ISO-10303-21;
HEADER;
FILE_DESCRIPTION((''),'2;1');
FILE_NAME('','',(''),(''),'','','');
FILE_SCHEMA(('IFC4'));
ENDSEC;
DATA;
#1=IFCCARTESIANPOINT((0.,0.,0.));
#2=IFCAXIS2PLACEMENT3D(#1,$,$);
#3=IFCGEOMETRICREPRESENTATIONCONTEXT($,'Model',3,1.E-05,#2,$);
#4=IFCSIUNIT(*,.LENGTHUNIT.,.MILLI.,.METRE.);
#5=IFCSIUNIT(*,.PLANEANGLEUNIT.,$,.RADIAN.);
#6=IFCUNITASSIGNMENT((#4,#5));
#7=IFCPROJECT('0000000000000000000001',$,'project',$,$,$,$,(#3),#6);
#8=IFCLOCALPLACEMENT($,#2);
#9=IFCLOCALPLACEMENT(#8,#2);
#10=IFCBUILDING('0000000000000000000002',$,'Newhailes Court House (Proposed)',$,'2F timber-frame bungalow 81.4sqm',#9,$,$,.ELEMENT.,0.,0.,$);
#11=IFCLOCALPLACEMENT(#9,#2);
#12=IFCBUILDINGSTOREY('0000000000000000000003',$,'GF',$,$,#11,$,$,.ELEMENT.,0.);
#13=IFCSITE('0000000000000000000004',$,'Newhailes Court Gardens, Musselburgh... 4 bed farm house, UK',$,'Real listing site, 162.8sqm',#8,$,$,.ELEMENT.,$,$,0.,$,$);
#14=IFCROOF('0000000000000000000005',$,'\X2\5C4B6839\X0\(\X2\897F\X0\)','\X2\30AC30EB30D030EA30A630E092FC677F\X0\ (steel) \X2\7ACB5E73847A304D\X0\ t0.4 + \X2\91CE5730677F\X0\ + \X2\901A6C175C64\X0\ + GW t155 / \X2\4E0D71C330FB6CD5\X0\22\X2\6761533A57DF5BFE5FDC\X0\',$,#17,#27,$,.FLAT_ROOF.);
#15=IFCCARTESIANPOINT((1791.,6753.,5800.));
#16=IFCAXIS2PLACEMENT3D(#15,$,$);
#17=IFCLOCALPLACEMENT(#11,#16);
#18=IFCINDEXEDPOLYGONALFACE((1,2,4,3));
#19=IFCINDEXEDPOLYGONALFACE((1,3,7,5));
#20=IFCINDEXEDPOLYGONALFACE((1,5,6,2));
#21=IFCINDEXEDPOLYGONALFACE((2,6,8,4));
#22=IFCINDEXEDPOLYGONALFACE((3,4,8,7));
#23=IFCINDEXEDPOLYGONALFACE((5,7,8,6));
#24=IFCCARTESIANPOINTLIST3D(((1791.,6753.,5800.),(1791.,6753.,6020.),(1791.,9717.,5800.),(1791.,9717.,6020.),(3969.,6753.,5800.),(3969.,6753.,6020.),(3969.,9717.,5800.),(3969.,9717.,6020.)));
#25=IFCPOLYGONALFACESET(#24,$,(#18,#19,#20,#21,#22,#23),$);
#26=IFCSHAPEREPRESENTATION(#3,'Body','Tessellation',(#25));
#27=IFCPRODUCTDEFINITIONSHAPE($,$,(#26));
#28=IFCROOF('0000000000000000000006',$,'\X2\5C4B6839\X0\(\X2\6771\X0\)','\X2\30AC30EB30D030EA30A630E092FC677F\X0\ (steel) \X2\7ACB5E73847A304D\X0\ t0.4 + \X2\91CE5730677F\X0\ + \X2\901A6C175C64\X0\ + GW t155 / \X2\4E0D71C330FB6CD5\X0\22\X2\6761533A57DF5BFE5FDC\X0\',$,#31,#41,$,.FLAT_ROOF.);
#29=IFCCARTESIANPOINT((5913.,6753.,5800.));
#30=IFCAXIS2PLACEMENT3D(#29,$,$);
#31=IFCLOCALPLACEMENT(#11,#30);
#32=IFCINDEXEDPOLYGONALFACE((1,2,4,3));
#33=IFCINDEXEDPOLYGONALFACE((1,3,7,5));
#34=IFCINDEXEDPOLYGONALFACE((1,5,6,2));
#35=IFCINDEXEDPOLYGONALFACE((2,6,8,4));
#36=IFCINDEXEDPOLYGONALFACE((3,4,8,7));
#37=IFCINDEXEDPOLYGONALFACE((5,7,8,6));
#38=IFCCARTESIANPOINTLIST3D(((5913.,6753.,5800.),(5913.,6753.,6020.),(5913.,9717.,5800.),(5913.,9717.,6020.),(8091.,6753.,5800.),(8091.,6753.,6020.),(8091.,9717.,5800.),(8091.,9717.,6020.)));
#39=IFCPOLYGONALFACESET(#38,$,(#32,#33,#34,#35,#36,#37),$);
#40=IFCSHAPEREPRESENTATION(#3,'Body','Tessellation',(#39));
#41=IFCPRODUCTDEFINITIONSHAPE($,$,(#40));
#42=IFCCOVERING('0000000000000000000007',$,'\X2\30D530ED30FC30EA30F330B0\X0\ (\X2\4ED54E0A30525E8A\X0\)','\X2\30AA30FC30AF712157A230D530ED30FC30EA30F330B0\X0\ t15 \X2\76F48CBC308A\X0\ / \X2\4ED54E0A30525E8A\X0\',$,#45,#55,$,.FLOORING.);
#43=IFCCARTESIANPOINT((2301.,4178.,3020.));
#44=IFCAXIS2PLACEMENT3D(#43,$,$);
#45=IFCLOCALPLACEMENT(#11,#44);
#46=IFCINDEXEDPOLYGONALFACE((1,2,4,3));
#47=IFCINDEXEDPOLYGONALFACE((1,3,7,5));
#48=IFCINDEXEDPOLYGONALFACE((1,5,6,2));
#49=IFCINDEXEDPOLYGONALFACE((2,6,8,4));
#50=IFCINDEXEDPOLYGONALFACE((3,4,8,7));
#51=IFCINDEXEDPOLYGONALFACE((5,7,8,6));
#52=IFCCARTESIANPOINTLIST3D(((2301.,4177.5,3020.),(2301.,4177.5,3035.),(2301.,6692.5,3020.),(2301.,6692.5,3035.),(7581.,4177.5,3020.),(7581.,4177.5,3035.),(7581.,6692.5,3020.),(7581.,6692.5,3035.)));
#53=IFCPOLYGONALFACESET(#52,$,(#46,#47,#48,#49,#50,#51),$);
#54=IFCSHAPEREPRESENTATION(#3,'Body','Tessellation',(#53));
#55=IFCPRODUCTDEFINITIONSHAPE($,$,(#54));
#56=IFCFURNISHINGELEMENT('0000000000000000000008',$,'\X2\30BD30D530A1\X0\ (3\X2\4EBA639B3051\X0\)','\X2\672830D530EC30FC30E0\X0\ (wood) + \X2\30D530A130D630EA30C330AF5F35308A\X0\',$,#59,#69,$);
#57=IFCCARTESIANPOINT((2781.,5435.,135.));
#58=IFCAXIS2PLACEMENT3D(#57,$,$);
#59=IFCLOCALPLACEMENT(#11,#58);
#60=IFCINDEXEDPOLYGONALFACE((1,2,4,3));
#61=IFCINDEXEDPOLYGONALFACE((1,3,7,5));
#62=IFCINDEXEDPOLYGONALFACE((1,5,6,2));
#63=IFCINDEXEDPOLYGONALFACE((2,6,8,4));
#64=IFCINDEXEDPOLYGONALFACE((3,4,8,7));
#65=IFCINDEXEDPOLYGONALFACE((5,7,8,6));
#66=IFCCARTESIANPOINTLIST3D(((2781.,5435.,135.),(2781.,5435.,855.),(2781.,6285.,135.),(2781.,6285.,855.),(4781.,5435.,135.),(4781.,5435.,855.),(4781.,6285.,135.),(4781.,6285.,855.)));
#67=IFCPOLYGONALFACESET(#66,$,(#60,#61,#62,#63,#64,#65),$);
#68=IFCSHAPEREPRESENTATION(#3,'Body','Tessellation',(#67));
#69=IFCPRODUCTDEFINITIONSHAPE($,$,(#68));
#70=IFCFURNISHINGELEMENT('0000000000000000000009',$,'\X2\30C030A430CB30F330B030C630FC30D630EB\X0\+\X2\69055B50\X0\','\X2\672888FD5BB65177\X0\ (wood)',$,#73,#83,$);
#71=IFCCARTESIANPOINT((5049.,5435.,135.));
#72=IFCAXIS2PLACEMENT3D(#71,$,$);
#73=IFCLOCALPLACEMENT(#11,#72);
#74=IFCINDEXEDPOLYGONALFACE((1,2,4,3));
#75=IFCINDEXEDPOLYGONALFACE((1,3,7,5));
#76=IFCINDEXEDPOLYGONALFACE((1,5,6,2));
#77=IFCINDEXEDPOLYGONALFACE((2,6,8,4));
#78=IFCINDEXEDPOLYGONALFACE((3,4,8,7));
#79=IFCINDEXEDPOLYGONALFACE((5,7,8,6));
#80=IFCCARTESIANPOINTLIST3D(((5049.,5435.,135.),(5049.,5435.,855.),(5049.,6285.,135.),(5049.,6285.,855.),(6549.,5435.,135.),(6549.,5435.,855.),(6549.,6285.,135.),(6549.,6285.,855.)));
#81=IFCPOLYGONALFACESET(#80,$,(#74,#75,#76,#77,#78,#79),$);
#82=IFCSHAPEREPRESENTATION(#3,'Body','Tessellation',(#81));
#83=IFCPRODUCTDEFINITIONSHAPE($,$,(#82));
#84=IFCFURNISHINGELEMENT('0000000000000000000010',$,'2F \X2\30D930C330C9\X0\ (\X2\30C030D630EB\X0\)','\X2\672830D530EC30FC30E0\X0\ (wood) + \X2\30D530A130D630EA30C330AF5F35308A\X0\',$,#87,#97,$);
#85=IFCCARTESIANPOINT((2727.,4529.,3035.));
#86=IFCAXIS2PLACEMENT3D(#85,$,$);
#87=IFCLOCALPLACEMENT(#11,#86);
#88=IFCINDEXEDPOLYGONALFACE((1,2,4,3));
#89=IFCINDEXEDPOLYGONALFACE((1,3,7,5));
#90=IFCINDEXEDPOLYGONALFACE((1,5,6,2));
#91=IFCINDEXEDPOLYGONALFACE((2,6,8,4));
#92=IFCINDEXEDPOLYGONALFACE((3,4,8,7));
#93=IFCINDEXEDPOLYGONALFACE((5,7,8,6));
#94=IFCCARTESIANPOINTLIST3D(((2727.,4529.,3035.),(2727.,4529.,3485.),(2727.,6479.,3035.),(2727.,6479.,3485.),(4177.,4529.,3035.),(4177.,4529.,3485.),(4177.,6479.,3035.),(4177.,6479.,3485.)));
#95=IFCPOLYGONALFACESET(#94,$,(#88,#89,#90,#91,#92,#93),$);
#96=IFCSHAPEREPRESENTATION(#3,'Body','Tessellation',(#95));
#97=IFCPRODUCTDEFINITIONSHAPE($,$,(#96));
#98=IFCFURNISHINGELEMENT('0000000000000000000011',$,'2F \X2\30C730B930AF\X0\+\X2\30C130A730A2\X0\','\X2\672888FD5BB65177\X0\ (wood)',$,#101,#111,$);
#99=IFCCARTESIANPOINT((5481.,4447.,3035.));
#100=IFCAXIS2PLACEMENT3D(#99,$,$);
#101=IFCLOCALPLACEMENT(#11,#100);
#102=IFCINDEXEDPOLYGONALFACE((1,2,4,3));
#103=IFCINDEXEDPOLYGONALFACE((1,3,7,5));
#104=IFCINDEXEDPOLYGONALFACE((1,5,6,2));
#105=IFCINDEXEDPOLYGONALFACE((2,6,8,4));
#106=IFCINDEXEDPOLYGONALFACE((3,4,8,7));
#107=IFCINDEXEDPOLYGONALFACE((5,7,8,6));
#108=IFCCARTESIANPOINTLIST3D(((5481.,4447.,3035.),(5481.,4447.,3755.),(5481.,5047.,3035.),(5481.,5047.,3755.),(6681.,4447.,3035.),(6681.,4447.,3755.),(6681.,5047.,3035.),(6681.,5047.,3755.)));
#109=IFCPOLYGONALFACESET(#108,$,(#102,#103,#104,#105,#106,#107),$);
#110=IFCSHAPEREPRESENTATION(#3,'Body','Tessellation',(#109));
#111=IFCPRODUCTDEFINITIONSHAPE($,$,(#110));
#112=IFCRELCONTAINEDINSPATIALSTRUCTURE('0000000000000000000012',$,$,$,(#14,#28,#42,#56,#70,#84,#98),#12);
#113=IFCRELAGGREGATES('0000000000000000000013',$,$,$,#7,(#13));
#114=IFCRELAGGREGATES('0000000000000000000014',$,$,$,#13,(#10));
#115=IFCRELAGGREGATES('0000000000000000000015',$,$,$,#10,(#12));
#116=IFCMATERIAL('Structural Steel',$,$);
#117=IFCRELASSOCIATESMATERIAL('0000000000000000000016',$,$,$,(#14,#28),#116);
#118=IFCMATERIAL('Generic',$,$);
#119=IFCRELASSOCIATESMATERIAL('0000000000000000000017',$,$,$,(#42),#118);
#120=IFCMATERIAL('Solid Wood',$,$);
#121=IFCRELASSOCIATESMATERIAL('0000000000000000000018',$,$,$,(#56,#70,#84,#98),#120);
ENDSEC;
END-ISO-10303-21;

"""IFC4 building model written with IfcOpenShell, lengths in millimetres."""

from ifc_helpers import new_model, si_unit, frame, frame_2d, origin, place, context, project, spatial, rectangle, extrude, material, element, save


model = new_model("IFC4")

# Units and contexts
model_context = context("Model", 3, precision=1e-05, world=origin())
ifc_project = project(units=[si_unit("LENGTHUNIT", "METRE", prefix="MILLI"), si_unit("PLANEANGLEUNIT", "RADIAN")], contexts=[model_context])

# Site, building, storey
site_placement = place(None, origin())
site = spatial("IfcSite", under=ifc_project, at=site_placement, Name="Newhailes Court Gardens, Musselburgh... 4 bed farm house, UK", ObjectType="Real listing site, 162.8sqm", CompositionType="ELEMENT", RefElevation=0.0)
building_placement = place(site_placement, origin())
building = spatial("IfcBuilding", under=site, at=building_placement, Name="Newhailes Court House (Proposed)", ObjectType="2F timber-frame bungalow 81.4sqm", CompositionType="ELEMENT", ElevationOfRefHeight=0.0, ElevationOfTerrain=0.0)
storey_placement = place(building_placement, origin())
storey = spatial("IfcBuildingStorey", under=building, at=storey_placement, Name="GF", CompositionType="ELEMENT", Elevation=0.0)

# Shared definitions
ifc_material_1 = material(Name="Solid Wood")

# Roofs
ifc_material_2 = material(Name="Structural Steel")
roof_1_placement = place(storey_placement, frame((1791.0, 6753.0, 5800.0)))
element("IfcRoof", 1, at=roof_1_placement, inside=storey, material=ifc_material_2, Name="屋根(西)", Description="ガルバリウム鋼板 (steel) 立平葺き t0.4 + 野地板 + 通気層 + GW t155 / 不燃・法22条区域対応", PredefinedType="FLAT_ROOF", context=model_context, shape_type="SweptSolid", body=[
    extrude(rectangle(XDim=2178.0, YDim=2964.0, at=frame_2d((1089.0, 1482.0))), frame((1791.0, 6753.0, 5800.0)), (0.0, 0.0, 1.0), 220.0),
])
roof_2_placement = place(storey_placement, frame((5913.0, 6753.0, 5800.0)))
element("IfcRoof", 2, at=roof_2_placement, inside=storey, material=ifc_material_2, Name="屋根(東)", Description="ガルバリウム鋼板 (steel) 立平葺き t0.4 + 野地板 + 通気層 + GW t155 / 不燃・法22条区域対応", PredefinedType="FLAT_ROOF", context=model_context, shape_type="SweptSolid", body=[
    extrude(rectangle(XDim=2178.0, YDim=2964.0, at=frame_2d((1089.0, 1482.0))), frame((5913.0, 6753.0, 5800.0)), (0.0, 0.0, 1.0), 220.0),
])

# Covering
ifc_material_3 = material(Name="Generic")
covering_placement = place(storey_placement, frame((2301.0, 4178.0, 3020.0)))
element("IfcCovering", 3, at=covering_placement, inside=storey, material=ifc_material_3, Name="フローリング (仕上げ床)", Description="オーク無垢フローリング t15 直貼り / 仕上げ床", PredefinedType="FLOORING", context=model_context, shape_type="SweptSolid", body=[
    extrude(rectangle(XDim=5280.0, YDim=2515.0, at=frame_2d((2640.0, 1257.0))), frame((2301.0, 4178.0, 3020.0)), (0.0, 0.0, 1.0), 15.0),
])

# Furnishing elements
furnishing_1_placement = place(storey_placement, frame((2781.0, 5435.0, 135.0)))
element("IfcFurnishingElement", 4, at=furnishing_1_placement, inside=storey, material=ifc_material_1, Name="ソファ (3人掛け)", Description="木フレーム (wood) + ファブリック張り", context=model_context, shape_type="SweptSolid", body=[
    extrude(rectangle(XDim=2000.0, YDim=850.0, at=frame_2d((1000.0, 425.0))), frame((2781.0, 5435.0, 135.0)), (0.0, 0.0, 1.0), 720.0),
])
furnishing_2_placement = place(storey_placement, frame((5049.0, 5435.0, 135.0)))
element("IfcFurnishingElement", 5, at=furnishing_2_placement, inside=storey, material=ifc_material_1, Name="ダイニングテーブル+椅子", Description="木製家具 (wood)", context=model_context, shape_type="SweptSolid", body=[
    extrude(rectangle(XDim=1500.0, YDim=850.0, at=frame_2d((750.0, 425.0))), frame((5049.0, 5435.0, 135.0)), (0.0, 0.0, 1.0), 720.0),
])
furnishing_3_placement = place(storey_placement, frame((2727.0, 4529.0, 3035.0)))
element("IfcFurnishingElement", 6, at=furnishing_3_placement, inside=storey, material=ifc_material_1, Name="2F ベッド (ダブル)", Description="木フレーム (wood) + ファブリック張り", context=model_context, shape_type="SweptSolid", body=[
    extrude(rectangle(XDim=1450.0, YDim=1950.0, at=frame_2d((725.0, 975.0))), frame((2727.0, 4529.0, 3035.0)), (0.0, 0.0, 1.0), 450.0),
])
furnishing_4_placement = place(storey_placement, frame((5481.0, 4447.0, 3035.0)))
element("IfcFurnishingElement", 7, at=furnishing_4_placement, inside=storey, material=ifc_material_1, Name="2F デスク+チェア", Description="木製家具 (wood)", context=model_context, shape_type="SweptSolid", body=[
    extrude(rectangle(XDim=1200.0, YDim=600.0, at=frame_2d((600.0, 300.0))), frame((5481.0, 4447.0, 3035.0)), (0.0, 0.0, 1.0), 720.0),
])

save(model, "model.ifc")
